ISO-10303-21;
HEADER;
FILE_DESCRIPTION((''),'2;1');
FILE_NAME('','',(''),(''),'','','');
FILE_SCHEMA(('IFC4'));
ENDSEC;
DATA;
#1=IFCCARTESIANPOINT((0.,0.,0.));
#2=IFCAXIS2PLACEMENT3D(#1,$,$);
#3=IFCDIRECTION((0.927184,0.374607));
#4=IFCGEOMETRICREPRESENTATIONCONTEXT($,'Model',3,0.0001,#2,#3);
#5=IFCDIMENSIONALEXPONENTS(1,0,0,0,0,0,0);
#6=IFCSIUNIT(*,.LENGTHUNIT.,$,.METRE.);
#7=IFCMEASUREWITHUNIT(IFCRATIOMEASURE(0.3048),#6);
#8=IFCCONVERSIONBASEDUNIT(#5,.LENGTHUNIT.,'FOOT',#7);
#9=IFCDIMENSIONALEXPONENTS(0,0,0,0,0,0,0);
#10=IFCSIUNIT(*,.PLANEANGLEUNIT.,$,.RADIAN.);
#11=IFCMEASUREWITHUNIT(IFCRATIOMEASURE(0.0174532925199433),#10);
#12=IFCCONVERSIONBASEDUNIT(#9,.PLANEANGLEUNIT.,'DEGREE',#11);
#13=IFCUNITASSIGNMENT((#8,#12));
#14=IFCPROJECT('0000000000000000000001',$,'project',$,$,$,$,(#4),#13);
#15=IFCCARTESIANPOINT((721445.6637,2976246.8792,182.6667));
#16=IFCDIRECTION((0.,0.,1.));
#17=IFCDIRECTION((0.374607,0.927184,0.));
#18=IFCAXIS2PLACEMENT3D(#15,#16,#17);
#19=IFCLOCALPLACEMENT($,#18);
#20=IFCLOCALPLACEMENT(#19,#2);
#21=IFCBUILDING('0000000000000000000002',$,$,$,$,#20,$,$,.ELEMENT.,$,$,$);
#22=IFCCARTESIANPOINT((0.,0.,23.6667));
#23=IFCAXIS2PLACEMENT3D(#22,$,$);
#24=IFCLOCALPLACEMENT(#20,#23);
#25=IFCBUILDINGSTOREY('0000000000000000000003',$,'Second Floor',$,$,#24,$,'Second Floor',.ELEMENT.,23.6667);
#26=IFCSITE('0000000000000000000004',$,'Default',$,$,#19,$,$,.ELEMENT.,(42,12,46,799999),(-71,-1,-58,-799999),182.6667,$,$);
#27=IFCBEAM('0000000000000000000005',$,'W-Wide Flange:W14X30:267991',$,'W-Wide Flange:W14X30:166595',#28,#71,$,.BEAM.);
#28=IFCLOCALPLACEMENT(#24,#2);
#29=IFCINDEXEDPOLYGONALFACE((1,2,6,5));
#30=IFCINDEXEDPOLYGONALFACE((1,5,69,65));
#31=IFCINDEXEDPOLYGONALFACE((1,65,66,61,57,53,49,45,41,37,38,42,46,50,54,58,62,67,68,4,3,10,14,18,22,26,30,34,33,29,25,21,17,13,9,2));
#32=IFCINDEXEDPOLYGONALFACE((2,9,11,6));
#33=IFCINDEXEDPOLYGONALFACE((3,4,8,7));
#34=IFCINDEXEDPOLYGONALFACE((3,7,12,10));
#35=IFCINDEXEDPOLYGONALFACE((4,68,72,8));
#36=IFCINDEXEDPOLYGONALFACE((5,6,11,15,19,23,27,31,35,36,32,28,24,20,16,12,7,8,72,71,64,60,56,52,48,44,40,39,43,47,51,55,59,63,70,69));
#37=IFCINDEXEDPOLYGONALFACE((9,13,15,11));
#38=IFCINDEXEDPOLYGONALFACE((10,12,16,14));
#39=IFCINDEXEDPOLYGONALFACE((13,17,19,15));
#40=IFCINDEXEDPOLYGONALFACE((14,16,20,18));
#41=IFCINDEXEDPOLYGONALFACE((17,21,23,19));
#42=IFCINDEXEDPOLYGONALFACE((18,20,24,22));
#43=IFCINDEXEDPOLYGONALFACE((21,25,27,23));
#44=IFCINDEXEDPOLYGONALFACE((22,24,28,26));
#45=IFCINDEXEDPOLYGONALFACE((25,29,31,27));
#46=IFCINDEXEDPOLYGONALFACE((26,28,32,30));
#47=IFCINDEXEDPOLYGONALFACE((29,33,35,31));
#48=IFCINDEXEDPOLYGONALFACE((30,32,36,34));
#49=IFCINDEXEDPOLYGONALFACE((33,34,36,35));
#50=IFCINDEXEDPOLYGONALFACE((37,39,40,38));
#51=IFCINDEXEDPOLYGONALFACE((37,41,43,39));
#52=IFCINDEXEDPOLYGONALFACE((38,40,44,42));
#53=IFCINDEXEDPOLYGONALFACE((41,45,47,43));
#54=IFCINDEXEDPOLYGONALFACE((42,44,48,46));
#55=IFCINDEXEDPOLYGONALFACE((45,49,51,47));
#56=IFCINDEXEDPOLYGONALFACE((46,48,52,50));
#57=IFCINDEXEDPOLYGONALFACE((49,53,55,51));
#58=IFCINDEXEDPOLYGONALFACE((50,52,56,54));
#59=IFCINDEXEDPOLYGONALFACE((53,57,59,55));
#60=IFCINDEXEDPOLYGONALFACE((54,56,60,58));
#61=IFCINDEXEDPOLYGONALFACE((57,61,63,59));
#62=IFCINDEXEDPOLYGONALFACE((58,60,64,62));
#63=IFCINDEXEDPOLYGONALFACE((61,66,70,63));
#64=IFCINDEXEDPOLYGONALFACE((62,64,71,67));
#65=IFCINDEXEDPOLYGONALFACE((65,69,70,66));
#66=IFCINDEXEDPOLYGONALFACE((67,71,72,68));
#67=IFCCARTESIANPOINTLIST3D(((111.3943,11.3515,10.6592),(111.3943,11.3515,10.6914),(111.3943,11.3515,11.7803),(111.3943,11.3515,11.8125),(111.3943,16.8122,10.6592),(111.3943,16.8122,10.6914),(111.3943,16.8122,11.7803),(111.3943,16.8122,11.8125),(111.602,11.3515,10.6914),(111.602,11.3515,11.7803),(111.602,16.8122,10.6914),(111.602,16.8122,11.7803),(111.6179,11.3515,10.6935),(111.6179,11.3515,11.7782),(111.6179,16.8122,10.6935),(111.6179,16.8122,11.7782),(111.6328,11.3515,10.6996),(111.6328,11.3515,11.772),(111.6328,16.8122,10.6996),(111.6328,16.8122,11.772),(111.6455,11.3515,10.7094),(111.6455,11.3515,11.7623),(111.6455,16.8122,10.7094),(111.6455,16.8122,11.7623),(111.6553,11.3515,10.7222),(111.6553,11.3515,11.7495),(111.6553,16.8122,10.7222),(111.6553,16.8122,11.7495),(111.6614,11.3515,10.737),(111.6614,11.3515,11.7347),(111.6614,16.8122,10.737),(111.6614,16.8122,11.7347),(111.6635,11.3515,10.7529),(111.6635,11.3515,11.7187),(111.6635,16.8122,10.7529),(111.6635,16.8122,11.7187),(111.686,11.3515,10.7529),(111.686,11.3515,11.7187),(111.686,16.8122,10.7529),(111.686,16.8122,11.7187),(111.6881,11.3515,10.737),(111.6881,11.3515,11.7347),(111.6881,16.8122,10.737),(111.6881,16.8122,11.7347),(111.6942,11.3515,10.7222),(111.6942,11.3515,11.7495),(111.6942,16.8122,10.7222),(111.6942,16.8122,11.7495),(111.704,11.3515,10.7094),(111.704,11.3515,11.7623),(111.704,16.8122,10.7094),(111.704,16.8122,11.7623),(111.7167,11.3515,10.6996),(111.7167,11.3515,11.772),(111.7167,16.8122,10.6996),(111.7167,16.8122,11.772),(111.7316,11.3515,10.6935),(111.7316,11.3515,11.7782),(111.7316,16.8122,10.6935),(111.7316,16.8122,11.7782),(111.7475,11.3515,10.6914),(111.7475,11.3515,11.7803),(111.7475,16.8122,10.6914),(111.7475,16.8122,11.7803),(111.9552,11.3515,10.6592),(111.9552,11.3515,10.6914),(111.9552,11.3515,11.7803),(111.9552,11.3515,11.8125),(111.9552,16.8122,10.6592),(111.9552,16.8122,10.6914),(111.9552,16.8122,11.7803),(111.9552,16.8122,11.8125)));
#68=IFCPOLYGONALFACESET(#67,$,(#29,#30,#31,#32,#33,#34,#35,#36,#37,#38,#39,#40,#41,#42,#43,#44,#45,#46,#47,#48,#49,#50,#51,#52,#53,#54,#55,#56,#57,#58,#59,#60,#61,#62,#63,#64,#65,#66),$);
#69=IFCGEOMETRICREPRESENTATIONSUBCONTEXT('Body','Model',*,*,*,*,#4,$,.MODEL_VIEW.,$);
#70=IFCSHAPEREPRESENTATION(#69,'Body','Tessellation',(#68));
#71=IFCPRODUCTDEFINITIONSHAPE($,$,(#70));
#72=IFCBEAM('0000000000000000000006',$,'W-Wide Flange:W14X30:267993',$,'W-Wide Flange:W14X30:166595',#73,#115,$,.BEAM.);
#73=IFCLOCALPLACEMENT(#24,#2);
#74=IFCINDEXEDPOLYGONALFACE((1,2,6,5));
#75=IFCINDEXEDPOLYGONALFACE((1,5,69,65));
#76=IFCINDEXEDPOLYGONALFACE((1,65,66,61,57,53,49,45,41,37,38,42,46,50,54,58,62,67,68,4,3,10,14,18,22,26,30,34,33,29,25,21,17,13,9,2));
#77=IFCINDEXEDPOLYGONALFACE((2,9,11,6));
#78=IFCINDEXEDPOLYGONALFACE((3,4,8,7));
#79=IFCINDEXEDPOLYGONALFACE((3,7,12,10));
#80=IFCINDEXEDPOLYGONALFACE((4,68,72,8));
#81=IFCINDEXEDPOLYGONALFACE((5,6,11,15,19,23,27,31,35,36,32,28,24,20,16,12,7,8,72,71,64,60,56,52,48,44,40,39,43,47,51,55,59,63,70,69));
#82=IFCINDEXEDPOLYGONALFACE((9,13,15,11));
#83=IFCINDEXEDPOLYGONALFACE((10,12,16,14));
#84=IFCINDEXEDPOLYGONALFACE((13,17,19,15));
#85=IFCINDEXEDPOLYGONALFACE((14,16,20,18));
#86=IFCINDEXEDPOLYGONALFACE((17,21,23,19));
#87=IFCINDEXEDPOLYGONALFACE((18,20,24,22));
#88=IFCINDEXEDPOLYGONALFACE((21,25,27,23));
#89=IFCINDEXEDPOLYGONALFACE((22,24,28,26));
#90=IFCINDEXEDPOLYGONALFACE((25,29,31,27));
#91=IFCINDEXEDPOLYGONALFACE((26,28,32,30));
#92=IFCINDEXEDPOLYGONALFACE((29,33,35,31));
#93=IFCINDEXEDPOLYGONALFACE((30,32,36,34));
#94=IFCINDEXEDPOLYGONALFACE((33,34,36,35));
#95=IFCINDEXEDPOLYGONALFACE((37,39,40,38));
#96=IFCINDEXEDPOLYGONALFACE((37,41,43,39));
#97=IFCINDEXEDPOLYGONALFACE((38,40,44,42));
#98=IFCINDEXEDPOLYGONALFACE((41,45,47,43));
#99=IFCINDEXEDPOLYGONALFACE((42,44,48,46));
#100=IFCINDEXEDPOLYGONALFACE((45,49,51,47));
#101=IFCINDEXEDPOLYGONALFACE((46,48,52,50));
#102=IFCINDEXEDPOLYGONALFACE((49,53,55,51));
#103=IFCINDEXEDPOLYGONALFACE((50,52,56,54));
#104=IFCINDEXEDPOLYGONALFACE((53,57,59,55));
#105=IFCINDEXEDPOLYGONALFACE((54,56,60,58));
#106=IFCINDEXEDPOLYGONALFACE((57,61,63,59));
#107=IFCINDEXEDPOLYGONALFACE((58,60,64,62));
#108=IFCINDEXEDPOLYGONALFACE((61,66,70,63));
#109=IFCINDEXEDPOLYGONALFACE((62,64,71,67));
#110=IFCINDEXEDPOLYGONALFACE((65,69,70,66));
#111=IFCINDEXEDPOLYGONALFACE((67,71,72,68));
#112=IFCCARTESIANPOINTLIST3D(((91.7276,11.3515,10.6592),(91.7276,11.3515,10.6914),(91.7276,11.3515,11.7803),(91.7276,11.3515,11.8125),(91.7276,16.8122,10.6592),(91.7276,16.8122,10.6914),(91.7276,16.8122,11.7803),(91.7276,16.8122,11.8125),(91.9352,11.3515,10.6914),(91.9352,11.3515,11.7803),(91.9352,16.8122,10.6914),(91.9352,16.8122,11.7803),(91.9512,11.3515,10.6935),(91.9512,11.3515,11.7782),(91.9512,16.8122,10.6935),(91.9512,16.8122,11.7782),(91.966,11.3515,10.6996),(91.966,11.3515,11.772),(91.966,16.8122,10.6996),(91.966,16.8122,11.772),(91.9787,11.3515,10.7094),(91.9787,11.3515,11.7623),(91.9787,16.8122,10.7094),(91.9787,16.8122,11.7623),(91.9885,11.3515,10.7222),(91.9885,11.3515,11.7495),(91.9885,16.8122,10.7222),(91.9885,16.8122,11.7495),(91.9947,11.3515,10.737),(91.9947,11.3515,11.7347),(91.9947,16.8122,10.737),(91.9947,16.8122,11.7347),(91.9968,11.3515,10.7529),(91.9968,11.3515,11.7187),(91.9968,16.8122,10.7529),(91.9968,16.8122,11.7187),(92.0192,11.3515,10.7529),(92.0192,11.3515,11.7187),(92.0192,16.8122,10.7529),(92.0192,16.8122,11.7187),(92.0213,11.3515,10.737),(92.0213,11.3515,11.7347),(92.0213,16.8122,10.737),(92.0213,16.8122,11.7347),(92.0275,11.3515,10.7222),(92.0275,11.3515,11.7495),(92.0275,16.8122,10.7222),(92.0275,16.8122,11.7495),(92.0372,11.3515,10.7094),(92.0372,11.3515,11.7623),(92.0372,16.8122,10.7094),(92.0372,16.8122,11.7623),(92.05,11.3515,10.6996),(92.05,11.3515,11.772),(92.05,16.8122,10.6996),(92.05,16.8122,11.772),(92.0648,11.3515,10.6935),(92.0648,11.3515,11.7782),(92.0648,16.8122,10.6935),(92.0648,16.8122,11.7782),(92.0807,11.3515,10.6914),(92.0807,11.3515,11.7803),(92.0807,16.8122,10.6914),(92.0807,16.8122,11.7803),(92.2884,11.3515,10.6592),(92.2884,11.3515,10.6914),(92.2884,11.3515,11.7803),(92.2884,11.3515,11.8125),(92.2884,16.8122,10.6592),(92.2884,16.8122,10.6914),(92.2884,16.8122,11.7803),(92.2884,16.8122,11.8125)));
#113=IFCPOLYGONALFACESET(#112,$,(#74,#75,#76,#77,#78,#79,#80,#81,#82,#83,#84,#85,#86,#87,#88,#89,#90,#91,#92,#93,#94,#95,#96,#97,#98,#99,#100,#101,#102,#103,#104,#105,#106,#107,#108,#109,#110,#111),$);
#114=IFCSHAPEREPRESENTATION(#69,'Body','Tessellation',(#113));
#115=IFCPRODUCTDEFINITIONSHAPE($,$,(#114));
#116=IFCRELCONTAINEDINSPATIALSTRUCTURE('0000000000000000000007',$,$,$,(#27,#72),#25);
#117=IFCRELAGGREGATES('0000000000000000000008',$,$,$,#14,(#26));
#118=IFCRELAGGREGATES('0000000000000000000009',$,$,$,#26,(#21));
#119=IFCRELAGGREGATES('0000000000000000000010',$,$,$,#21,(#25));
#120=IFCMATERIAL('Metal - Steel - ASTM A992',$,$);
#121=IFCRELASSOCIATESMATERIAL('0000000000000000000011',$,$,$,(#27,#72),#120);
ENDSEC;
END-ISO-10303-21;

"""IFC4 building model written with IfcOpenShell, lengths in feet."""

from ifc_helpers import new_model, entity, si_unit, converted_unit, direction, frame, frame_2d, origin, place, context, subcontext, project, spatial, i_section, extrude, material, element, save


model = new_model("IFC4")

# Units and contexts
model_context = context("Model", 3, precision=0.0001, world=origin(), true_north=direction((0.927184, 0.374607)))
body_context = subcontext(model_context, "Body", "Model", "MODEL_VIEW")
ifc_project = project(units=[converted_unit("LENGTHUNIT", "FOOT", entity("IfcRatioMeasure", 0.3048), si_unit("LENGTHUNIT", "METRE"), dimensions=[1, 0, 0, 0, 0, 0, 0]), converted_unit("PLANEANGLEUNIT", "DEGREE", entity("IfcRatioMeasure", 0.0174532925199433), si_unit("PLANEANGLEUNIT", "RADIAN"), dimensions=[0, 0, 0, 0, 0, 0, 0])], contexts=[model_context])

# Site, building, storey
site_placement = place(None, frame((721445.6637, 2976246.8792, 182.6667), z_axis=(0.0, 0.0, 1.0), x_axis=(0.374607, 0.927184, 0.0)))
site = spatial("IfcSite", under=ifc_project, at=site_placement, Name="Default", CompositionType="ELEMENT", RefLatitude=(42, 12, 46, 799999), RefLongitude=(-71, -1, -58, -799999), RefElevation=182.6667)
building_placement = place(site_placement, origin())
building = spatial("IfcBuilding", under=site, at=building_placement, CompositionType="ELEMENT")
storey_placement = place(building_placement, frame((0.0, 0.0, 23.6667)))
storey = spatial("IfcBuildingStorey", under=building, at=storey_placement, Name="Second Floor", LongName="Second Floor", CompositionType="ELEMENT", Elevation=23.6667)

# Shared definitions
ifc_material_1 = material(Name="Metal - Steel - ASTM A992")

# Beams
beam_1_placement = place(storey_placement, frame((111.6748, 11.1456, 11.8125), z_axis=(0.0, 0.0, 1.0), x_axis=(0.0, 1.0, 0.0)))
element("IfcBeam", 1, at=beam_1_placement, inside=storey, material=ifc_material_1, Name="W-Wide Flange:W14X30:267991", ObjectType="W-Wide Flange:W14X30:166595", PredefinedType="BEAM", context=body_context, shape_type="SweptSolid", body=[
    extrude(i_section(OverallWidth=0.5609, OverallDepth=1.1533, WebThickness=0.0225, FlangeThickness=0.0322, FilletRadius=0.0615, at=frame_2d((0.0, 0.0), x_axis=(0.0, 1.0))), frame((0.2059, 0.0, -0.5767), z_axis=(1.0, 0.0, 0.0), x_axis=(0.0, 0.0, -1.0)), (0.0, 0.0, 1.0), 5.4608),
])
beam_2_placement = place(storey_placement, frame((92.008, 11.1456, 11.8125), z_axis=(0.0, 0.0, 1.0), x_axis=(0.0, 1.0, 0.0)))
element("IfcBeam", 2, at=beam_2_placement, inside=storey, material=ifc_material_1, Name="W-Wide Flange:W14X30:267993", ObjectType="W-Wide Flange:W14X30:166595", PredefinedType="BEAM", context=body_context, shape_type="SweptSolid", body=[
    extrude(i_section(OverallWidth=0.5609, OverallDepth=1.1533, WebThickness=0.0225, FlangeThickness=0.0322, FilletRadius=0.0615, at=frame_2d((0.0, 0.0), x_axis=(0.0, 1.0))), frame((0.2059, 0.0, -0.5767), z_axis=(1.0, 0.0, 0.0), x_axis=(0.0, 0.0, -1.0)), (0.0, 0.0, 1.0), 5.4608),
])

save(model, "model.ifc")
